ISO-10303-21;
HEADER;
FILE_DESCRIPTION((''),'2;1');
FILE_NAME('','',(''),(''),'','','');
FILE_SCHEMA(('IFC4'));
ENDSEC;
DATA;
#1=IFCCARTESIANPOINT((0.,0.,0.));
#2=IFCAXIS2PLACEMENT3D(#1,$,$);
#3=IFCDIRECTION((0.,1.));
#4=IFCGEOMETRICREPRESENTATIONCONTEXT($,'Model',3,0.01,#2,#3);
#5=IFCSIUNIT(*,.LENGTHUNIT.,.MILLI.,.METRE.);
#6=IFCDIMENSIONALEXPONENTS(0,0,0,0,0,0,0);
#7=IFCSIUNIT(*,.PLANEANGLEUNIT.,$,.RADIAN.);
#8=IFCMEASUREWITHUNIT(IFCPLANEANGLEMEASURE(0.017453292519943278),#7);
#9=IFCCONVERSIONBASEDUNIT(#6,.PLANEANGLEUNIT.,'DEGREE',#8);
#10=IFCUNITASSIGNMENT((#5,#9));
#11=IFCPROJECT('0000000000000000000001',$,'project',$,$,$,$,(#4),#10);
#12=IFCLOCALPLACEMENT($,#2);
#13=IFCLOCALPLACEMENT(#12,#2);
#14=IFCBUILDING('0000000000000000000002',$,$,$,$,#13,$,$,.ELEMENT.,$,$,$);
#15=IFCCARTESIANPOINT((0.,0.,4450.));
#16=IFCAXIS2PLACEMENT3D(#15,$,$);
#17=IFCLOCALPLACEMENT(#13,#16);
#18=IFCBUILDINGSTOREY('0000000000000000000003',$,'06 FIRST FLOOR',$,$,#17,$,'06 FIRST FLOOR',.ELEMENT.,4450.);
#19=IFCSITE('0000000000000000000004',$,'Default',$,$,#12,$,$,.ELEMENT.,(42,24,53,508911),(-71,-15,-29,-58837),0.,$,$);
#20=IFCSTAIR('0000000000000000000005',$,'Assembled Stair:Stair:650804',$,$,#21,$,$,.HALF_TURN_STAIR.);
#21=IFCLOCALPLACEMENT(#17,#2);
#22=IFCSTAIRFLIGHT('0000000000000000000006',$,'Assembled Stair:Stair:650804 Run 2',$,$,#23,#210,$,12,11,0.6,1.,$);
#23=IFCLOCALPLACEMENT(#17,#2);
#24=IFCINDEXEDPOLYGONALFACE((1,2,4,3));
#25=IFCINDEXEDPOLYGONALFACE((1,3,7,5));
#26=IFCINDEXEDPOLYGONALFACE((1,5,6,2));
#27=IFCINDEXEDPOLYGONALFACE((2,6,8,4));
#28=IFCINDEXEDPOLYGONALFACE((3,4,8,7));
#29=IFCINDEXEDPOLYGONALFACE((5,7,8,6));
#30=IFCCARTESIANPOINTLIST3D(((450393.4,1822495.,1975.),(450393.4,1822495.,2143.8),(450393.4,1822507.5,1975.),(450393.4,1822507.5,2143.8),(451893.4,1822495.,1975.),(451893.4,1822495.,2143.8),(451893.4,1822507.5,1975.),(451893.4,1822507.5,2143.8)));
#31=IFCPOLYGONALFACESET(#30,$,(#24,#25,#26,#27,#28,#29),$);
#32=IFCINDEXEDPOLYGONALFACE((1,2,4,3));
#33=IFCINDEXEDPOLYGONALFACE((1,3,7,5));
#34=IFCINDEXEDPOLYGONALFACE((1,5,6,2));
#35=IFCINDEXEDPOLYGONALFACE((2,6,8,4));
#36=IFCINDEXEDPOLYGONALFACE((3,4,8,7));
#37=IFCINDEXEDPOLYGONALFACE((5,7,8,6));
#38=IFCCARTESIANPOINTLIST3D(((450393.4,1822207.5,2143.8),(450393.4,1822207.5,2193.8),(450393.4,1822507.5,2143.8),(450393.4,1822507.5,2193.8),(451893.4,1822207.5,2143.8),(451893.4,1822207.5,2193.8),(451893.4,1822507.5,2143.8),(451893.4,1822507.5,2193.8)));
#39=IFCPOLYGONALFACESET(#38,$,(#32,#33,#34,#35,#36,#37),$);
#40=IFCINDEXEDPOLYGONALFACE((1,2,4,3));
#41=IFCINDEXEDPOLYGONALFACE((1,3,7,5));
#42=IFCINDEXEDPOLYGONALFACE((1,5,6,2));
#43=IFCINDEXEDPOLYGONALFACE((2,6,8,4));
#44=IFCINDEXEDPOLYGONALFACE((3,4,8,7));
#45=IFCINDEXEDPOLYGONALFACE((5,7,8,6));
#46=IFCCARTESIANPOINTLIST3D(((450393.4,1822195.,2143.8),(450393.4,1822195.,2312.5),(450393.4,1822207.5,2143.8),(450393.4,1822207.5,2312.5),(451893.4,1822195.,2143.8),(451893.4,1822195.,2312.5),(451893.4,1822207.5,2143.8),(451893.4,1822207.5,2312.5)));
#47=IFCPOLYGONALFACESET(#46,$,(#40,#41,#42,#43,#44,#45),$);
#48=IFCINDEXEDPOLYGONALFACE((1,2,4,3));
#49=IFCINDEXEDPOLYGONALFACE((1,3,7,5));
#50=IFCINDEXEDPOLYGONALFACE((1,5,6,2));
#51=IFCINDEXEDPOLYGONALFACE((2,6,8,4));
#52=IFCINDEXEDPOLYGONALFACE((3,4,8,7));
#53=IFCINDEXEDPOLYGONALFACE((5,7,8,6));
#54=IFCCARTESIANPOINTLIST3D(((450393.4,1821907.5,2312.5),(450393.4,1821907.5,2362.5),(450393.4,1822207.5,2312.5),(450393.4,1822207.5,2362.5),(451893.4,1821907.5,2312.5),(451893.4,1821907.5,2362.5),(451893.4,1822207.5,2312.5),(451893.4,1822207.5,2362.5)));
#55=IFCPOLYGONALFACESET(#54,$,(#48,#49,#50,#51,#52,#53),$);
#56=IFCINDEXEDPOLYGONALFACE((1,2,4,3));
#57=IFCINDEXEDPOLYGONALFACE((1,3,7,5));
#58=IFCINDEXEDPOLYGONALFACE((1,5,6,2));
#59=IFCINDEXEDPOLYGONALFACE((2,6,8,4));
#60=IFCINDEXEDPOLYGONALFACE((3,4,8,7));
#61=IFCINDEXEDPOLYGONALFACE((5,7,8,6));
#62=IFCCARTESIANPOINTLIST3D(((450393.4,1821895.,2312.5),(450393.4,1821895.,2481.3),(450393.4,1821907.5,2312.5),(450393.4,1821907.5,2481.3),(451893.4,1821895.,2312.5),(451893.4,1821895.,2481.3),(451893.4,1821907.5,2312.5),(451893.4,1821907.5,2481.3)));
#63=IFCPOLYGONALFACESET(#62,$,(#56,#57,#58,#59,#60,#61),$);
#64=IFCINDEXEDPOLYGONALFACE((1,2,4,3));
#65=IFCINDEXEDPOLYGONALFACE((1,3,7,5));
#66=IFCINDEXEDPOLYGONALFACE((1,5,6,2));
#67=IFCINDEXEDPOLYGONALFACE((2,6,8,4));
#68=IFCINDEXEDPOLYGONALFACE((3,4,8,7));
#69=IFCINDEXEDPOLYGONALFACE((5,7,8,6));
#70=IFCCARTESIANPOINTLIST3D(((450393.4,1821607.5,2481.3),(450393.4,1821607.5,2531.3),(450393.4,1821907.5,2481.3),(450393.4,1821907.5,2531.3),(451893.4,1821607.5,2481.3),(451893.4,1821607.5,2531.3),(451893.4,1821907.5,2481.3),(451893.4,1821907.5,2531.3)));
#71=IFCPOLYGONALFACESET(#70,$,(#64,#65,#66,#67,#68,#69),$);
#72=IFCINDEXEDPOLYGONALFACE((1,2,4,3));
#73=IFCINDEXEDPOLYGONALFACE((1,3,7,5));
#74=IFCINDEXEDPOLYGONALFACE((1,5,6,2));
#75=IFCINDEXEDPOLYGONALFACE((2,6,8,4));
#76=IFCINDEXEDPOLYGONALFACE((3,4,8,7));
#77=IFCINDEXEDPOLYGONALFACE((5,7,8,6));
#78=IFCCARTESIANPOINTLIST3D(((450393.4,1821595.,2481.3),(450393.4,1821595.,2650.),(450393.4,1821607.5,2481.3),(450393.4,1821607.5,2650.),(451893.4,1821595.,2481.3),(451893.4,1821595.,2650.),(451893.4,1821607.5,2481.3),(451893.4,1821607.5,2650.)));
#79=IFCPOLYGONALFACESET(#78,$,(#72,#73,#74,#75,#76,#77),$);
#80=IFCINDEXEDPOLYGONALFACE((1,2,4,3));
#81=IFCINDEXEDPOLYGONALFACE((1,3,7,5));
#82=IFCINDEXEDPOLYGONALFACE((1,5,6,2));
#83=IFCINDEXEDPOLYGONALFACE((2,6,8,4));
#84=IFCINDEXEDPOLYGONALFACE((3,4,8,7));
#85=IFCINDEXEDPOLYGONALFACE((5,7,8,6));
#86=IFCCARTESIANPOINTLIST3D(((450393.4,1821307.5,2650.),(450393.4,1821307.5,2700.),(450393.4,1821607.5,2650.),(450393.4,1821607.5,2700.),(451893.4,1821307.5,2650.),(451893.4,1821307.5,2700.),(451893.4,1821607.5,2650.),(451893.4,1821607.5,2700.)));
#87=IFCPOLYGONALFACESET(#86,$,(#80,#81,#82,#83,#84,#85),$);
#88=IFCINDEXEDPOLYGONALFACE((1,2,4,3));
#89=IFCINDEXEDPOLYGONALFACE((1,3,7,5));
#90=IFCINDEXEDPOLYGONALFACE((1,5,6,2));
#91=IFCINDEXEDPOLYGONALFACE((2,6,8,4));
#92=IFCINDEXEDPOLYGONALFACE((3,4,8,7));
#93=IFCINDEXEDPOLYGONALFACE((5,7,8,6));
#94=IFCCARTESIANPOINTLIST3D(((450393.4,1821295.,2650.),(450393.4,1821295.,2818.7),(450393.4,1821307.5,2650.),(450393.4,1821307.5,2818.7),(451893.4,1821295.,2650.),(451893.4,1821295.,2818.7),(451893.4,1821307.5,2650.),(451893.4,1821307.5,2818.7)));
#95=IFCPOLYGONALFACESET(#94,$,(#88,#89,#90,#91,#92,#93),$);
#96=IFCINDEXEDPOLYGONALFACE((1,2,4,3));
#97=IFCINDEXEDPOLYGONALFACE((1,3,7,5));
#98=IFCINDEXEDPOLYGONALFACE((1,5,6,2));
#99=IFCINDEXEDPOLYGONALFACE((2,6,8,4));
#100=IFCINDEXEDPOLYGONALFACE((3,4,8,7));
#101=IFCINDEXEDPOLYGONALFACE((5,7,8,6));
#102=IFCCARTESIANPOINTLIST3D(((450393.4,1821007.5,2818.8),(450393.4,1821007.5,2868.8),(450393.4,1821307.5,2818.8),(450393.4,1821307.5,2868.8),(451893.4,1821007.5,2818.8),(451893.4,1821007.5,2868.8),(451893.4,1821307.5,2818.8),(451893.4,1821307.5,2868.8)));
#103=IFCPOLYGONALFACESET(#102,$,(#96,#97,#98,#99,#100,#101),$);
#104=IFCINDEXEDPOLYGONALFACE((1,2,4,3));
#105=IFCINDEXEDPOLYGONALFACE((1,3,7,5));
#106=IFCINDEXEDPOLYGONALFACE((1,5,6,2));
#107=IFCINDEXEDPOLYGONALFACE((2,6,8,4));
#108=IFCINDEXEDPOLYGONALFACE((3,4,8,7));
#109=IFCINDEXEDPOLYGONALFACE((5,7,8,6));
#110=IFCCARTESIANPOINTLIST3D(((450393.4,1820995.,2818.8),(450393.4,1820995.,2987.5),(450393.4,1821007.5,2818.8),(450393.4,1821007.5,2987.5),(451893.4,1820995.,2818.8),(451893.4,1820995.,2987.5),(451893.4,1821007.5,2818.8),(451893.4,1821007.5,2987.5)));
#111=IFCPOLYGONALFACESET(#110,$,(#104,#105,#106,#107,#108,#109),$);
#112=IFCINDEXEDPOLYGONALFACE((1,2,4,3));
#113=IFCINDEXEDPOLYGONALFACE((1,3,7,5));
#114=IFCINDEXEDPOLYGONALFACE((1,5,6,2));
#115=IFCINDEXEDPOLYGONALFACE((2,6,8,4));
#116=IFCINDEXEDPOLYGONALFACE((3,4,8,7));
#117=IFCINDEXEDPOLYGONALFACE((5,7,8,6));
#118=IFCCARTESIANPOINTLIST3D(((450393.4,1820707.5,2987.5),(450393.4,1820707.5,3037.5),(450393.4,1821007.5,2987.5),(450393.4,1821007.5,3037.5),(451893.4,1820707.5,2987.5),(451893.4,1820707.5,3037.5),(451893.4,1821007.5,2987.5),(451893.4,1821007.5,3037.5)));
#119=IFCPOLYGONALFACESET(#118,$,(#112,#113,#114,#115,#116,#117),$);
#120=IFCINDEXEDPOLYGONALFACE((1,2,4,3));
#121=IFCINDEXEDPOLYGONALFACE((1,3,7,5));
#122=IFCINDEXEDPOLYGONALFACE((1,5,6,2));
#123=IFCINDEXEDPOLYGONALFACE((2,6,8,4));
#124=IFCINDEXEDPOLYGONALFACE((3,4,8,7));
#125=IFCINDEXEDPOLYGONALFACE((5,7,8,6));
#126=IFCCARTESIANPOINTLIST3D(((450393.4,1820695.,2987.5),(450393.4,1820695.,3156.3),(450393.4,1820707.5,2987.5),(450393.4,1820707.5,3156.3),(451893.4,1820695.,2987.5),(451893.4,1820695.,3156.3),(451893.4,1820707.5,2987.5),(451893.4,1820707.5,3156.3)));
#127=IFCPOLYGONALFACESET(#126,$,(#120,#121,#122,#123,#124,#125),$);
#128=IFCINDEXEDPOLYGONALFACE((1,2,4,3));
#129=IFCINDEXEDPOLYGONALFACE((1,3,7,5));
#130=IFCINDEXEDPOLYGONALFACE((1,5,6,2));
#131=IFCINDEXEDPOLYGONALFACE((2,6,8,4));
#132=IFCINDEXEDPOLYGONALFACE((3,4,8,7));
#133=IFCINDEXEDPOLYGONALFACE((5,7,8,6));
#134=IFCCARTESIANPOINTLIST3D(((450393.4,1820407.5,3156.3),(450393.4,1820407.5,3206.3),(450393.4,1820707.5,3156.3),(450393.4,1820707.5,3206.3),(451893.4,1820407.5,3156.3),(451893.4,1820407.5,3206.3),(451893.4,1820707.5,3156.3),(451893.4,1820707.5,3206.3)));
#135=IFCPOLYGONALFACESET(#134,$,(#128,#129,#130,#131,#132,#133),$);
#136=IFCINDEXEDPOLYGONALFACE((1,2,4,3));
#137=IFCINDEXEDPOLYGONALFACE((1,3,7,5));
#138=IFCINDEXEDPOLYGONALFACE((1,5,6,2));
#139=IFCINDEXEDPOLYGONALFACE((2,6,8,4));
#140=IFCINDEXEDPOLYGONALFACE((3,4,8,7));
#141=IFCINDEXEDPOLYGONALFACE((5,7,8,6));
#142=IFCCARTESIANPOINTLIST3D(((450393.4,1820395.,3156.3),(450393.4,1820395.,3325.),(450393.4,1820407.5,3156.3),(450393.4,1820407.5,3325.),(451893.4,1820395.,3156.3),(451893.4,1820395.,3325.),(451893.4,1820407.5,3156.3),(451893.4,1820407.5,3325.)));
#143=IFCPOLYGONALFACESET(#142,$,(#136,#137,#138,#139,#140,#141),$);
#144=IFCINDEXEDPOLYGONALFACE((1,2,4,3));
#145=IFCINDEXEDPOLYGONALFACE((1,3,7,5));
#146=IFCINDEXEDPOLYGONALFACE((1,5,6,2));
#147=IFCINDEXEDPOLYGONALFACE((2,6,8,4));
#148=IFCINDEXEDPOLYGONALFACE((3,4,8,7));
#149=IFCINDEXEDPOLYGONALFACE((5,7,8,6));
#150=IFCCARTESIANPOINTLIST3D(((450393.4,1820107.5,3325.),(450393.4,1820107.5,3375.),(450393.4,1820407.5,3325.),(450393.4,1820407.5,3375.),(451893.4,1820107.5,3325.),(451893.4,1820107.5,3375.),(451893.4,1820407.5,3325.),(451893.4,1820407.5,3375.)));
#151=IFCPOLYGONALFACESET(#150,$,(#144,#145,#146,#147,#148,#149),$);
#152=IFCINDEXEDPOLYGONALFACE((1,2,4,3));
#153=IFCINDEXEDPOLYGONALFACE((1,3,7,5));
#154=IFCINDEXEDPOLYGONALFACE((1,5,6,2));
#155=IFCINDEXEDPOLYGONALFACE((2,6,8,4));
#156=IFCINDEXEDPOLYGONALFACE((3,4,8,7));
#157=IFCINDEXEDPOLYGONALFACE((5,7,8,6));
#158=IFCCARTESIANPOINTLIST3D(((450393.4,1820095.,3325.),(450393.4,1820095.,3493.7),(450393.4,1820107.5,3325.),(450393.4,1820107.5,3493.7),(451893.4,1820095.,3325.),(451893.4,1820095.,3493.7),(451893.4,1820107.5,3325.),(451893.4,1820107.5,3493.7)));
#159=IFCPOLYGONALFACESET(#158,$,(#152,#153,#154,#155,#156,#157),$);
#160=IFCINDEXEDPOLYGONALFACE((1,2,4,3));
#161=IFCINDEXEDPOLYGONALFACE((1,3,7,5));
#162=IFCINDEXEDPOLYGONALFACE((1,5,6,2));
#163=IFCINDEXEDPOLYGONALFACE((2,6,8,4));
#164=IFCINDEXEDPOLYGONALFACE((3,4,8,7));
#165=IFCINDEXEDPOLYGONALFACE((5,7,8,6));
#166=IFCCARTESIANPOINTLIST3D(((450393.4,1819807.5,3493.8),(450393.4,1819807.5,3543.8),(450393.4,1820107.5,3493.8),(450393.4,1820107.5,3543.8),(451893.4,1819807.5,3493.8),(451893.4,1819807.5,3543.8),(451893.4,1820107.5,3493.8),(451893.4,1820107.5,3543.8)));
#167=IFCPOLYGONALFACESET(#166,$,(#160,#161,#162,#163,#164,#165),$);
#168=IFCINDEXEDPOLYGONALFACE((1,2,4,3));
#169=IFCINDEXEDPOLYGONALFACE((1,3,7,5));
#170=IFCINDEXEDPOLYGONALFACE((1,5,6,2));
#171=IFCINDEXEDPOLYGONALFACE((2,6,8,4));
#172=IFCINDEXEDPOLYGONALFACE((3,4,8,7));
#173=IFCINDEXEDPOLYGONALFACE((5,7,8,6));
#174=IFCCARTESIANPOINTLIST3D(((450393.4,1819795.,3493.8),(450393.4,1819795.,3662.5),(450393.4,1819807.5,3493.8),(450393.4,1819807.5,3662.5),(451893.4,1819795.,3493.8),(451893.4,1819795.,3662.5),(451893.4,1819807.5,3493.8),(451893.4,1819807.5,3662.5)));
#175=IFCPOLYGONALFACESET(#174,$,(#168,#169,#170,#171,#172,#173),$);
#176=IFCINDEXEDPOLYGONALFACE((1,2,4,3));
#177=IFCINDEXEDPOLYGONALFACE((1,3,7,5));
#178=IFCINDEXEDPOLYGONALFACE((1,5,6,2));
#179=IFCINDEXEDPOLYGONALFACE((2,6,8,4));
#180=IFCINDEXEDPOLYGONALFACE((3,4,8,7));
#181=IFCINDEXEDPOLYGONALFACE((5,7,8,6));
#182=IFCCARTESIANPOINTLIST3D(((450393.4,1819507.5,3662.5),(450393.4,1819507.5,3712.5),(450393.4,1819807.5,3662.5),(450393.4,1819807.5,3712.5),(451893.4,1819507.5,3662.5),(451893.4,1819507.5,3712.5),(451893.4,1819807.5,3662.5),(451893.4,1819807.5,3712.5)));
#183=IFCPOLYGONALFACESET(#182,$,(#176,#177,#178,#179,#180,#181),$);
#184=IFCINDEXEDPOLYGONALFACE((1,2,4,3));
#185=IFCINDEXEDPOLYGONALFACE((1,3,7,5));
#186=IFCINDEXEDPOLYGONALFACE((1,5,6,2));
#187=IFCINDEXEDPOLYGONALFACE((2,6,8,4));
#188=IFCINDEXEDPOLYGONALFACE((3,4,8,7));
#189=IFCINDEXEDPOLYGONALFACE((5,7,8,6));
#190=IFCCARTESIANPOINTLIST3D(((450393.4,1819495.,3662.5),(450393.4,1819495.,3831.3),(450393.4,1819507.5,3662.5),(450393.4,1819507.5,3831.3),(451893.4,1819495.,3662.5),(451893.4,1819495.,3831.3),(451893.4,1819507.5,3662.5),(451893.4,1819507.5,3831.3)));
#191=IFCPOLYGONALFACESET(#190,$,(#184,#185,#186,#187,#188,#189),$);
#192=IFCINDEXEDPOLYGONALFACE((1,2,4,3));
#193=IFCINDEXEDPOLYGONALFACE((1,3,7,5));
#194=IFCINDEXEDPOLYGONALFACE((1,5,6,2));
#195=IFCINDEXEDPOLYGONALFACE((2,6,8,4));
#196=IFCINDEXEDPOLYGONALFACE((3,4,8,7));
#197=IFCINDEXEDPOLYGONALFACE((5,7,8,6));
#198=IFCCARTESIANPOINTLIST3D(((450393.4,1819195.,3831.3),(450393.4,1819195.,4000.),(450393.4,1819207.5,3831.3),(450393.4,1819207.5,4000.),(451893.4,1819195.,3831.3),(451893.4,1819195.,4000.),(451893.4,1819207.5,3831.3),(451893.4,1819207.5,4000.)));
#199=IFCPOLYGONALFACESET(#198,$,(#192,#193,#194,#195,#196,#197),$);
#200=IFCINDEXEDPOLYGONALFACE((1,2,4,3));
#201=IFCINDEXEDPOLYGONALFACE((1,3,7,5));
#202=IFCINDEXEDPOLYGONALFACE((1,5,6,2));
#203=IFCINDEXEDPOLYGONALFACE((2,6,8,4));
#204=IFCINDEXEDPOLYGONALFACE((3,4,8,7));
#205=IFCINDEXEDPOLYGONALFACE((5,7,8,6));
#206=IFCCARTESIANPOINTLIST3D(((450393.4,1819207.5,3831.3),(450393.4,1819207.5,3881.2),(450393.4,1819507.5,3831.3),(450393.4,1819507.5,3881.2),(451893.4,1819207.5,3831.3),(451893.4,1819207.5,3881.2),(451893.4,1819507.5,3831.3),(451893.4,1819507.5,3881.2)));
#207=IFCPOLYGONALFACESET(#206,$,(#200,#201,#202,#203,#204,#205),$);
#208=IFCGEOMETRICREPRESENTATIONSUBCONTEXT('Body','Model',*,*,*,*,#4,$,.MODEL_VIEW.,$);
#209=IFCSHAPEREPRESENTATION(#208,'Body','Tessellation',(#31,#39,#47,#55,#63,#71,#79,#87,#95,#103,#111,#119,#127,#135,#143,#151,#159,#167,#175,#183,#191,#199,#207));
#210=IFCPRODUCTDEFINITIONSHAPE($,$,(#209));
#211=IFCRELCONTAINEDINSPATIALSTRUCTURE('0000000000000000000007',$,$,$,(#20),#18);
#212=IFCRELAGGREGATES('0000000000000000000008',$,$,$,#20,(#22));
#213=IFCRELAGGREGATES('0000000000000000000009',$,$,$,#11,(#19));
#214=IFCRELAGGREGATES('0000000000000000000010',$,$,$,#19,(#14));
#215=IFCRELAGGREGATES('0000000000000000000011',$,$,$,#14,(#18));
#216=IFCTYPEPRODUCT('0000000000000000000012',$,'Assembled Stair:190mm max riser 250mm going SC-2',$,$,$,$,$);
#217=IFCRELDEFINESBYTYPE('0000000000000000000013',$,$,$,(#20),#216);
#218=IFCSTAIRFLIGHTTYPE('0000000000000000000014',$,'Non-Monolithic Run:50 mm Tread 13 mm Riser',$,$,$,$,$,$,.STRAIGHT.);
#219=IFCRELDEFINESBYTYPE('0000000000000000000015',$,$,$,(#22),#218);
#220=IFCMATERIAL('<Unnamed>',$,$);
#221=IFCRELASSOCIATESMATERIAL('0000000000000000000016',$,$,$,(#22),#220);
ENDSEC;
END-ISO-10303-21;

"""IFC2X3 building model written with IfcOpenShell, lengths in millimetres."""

from ifc_helpers import new_model, entity, si_unit, converted_unit, direction, frame, frame_2d, origin, origin_2d_with_axis, place, context, subcontext, project, spatial, rectangle, extrude, material, type_object, element, aggregate, save


model = new_model("IFC2X3")

# Units and contexts
model_context = context("Model", 3, precision=0.01, world=origin(), true_north=direction((0.0, 1.0)))
body_context = subcontext(model_context, "Body", "Model", "MODEL_VIEW")
ifc_project = project(units=[si_unit("LENGTHUNIT", "METRE", prefix="MILLI"), converted_unit("PLANEANGLEUNIT", "DEGREE", entity("IfcPlaneAngleMeasure", 0.017453292519943278), si_unit("PLANEANGLEUNIT", "RADIAN"), dimensions=[0, 0, 0, 0, 0, 0, 0])], contexts=[model_context])

# Site, building, storey
site_placement = place(None, origin())
site = spatial("IfcSite", under=ifc_project, at=site_placement, Name="Default", CompositionType="ELEMENT", RefLatitude=(42, 24, 53, 508911), RefLongitude=(-71, -15, -29, -58837), RefElevation=0.0)
building_placement = place(site_placement, origin())
building = spatial("IfcBuilding", under=site, at=building_placement, CompositionType="ELEMENT")
storey_placement = place(building_placement, frame((0.0, 0.0, 4450.0)))
storey = spatial("IfcBuildingStorey", under=building, at=storey_placement, Name="06 FIRST FLOOR", LongName="06 FIRST FLOOR", CompositionType="ELEMENT", Elevation=4450.0)

# Stair
ifc_material_1 = material(Name="<Unnamed>")
type_product_1 = type_object("IfcTypeProduct", Name="Assembled Stair:190mm max riser 250mm going SC-2")
stair_1_placement = place(storey_placement, origin())
stair_1 = element("IfcStair", 1, at=stair_1_placement, inside=storey, type_object=type_product_1, Name="Assembled Stair:Stair:650804", ShapeType="HALF_TURN_STAIR")

# Stair flight
stair_flight_type = type_object("IfcStairFlightType", Name="Non-Monolithic Run:50 mm Tread 13 mm Riser", PredefinedType="STRAIGHT")
stair_flight_1_placement = place(stair_1_placement, origin())
stair_flight_1 = element("IfcStairFlight", 2, at=stair_flight_1_placement, type_object=stair_flight_type, material=ifc_material_1, Name="Assembled Stair:Stair:650804 Run 2", NumberOfRiser=12, NumberOfTreads=11, RiserHeight=0.6, TreadLength=1.0, context=body_context, shape_type="SweptSolid", body=[
    extrude(rectangle(XDim=1500.0, YDim=12.5, at=origin_2d_with_axis()), frame((451143.4, 1822501.3, 1975.0)), (0.0, 0.0, 1.0), 168.8),
    extrude(rectangle(XDim=300.0, YDim=1500.0, at=frame_2d((0.0, 0.0), x_axis=(1.0, 0.0))), frame((451143.4, 1822357.5, 2143.8), z_axis=(0.0, 0.0, 1.0), x_axis=(0.0, 1.0, 0.0)), (0.0, 0.0, 1.0), 50.0),
    extrude(rectangle(XDim=1500.0, YDim=12.5, at=origin_2d_with_axis()), frame((451143.4, 1822201.3, 2143.8)), (0.0, 0.0, 1.0), 168.7),
    extrude(rectangle(XDim=300.0, YDim=1500.0, at=origin_2d_with_axis()), frame((451143.4, 1822057.5, 2312.5), z_axis=(0.0, 0.0, 1.0), x_axis=(0.0, 1.0, 0.0)), (0.0, 0.0, 1.0), 50.0),
    extrude(rectangle(XDim=1500.0, YDim=12.5, at=origin_2d_with_axis()), frame((451143.4, 1821901.3, 2312.5)), (0.0, 0.0, 1.0), 168.7),
    extrude(rectangle(XDim=300.0, YDim=1500.0, at=origin_2d_with_axis()), frame((451143.4, 1821757.5, 2481.3), z_axis=(0.0, 0.0, 1.0), x_axis=(0.0, 1.0, 0.0)), (0.0, 0.0, 1.0), 50.0),
    extrude(rectangle(XDim=1500.0, YDim=12.5, at=origin_2d_with_axis()), frame((451143.4, 1821601.3, 2481.3)), (0.0, 0.0, 1.0), 168.7),
    extrude(rectangle(XDim=300.0, YDim=1500.0, at=origin_2d_with_axis()), frame((451143.4, 1821457.5, 2650.0), z_axis=(0.0, 0.0, 1.0), x_axis=(0.0, 1.0, 0.0)), (0.0, 0.0, 1.0), 50.0),
    extrude(rectangle(XDim=1500.0, YDim=12.5, at=origin_2d_with_axis()), frame((451143.4, 1821301.3, 2650.0)), (0.0, 0.0, 1.0), 168.7),
    extrude(rectangle(XDim=300.0, YDim=1500.0, at=origin_2d_with_axis()), frame((451143.4, 1821157.5, 2818.8), z_axis=(0.0, 0.0, 1.0), x_axis=(0.0, 1.0, 0.0)), (0.0, 0.0, 1.0), 50.0),
    extrude(rectangle(XDim=1500.0, YDim=12.5, at=origin_2d_with_axis()), frame((451143.4, 1821001.3, 2818.8)), (0.0, 0.0, 1.0), 168.7),
    extrude(rectangle(XDim=300.0, YDim=1500.0, at=origin_2d_with_axis()), frame((451143.4, 1820857.5, 2987.5), z_axis=(0.0, 0.0, 1.0), x_axis=(0.0, 1.0, 0.0)), (0.0, 0.0, 1.0), 50.0),
    extrude(rectangle(XDim=1500.0, YDim=12.5, at=origin_2d_with_axis()), frame((451143.4, 1820701.3, 2987.5)), (0.0, 0.0, 1.0), 168.7),
    extrude(rectangle(XDim=300.0, YDim=1500.0, at=origin_2d_with_axis()), frame((451143.4, 1820557.5, 3156.3), z_axis=(0.0, 0.0, 1.0), x_axis=(0.0, 1.0, 0.0)), (0.0, 0.0, 1.0), 50.0),
    extrude(rectangle(XDim=1500.0, YDim=12.5, at=origin_2d_with_axis()), frame((451143.4, 1820401.3, 3156.3)), (0.0, 0.0, 1.0), 168.7),
    extrude(rectangle(XDim=300.0, YDim=1500.0, at=origin_2d_with_axis()), frame((451143.4, 1820257.5, 3325.0), z_axis=(0.0, 0.0, 1.0), x_axis=(0.0, 1.0, 0.0)), (0.0, 0.0, 1.0), 50.0),
    extrude(rectangle(XDim=1500.0, YDim=12.5, at=origin_2d_with_axis()), frame((451143.4, 1820101.3, 3325.0)), (0.0, 0.0, 1.0), 168.7),
    extrude(rectangle(XDim=300.0, YDim=1500.0, at=origin_2d_with_axis()), frame((451143.4, 1819957.5, 3493.8), z_axis=(0.0, 0.0, 1.0), x_axis=(0.0, 1.0, 0.0)), (0.0, 0.0, 1.0), 50.0),
    extrude(rectangle(XDim=1500.0, YDim=12.5, at=origin_2d_with_axis()), frame((451143.4, 1819801.3, 3493.8)), (0.0, 0.0, 1.0), 168.7),
    extrude(rectangle(XDim=300.0, YDim=1500.0, at=origin_2d_with_axis()), frame((451143.4, 1819657.5, 3662.5), z_axis=(0.0, 0.0, 1.0), x_axis=(0.0, 1.0, 0.0)), (0.0, 0.0, 1.0), 50.0),
    extrude(rectangle(XDim=1500.0, YDim=12.5, at=origin_2d_with_axis()), frame((451143.4, 1819501.3, 3662.5)), (0.0, 0.0, 1.0), 168.7),
    extrude(rectangle(XDim=1500.0, YDim=12.5, at=origin_2d_with_axis()), frame((451143.4, 1819201.3, 3831.3)), (0.0, 0.0, 1.0), 168.7),
    extrude(rectangle(XDim=300.0, YDim=1500.0, at=origin_2d_with_axis()), frame((451143.4, 1819357.5, 3831.3), z_axis=(0.0, 0.0, 1.0), x_axis=(0.0, 1.0, 0.0)), (0.0, 0.0, 1.0), 50.0),
])

aggregate(stair_1, [stair_flight_1])

save(model, "model.ifc")
